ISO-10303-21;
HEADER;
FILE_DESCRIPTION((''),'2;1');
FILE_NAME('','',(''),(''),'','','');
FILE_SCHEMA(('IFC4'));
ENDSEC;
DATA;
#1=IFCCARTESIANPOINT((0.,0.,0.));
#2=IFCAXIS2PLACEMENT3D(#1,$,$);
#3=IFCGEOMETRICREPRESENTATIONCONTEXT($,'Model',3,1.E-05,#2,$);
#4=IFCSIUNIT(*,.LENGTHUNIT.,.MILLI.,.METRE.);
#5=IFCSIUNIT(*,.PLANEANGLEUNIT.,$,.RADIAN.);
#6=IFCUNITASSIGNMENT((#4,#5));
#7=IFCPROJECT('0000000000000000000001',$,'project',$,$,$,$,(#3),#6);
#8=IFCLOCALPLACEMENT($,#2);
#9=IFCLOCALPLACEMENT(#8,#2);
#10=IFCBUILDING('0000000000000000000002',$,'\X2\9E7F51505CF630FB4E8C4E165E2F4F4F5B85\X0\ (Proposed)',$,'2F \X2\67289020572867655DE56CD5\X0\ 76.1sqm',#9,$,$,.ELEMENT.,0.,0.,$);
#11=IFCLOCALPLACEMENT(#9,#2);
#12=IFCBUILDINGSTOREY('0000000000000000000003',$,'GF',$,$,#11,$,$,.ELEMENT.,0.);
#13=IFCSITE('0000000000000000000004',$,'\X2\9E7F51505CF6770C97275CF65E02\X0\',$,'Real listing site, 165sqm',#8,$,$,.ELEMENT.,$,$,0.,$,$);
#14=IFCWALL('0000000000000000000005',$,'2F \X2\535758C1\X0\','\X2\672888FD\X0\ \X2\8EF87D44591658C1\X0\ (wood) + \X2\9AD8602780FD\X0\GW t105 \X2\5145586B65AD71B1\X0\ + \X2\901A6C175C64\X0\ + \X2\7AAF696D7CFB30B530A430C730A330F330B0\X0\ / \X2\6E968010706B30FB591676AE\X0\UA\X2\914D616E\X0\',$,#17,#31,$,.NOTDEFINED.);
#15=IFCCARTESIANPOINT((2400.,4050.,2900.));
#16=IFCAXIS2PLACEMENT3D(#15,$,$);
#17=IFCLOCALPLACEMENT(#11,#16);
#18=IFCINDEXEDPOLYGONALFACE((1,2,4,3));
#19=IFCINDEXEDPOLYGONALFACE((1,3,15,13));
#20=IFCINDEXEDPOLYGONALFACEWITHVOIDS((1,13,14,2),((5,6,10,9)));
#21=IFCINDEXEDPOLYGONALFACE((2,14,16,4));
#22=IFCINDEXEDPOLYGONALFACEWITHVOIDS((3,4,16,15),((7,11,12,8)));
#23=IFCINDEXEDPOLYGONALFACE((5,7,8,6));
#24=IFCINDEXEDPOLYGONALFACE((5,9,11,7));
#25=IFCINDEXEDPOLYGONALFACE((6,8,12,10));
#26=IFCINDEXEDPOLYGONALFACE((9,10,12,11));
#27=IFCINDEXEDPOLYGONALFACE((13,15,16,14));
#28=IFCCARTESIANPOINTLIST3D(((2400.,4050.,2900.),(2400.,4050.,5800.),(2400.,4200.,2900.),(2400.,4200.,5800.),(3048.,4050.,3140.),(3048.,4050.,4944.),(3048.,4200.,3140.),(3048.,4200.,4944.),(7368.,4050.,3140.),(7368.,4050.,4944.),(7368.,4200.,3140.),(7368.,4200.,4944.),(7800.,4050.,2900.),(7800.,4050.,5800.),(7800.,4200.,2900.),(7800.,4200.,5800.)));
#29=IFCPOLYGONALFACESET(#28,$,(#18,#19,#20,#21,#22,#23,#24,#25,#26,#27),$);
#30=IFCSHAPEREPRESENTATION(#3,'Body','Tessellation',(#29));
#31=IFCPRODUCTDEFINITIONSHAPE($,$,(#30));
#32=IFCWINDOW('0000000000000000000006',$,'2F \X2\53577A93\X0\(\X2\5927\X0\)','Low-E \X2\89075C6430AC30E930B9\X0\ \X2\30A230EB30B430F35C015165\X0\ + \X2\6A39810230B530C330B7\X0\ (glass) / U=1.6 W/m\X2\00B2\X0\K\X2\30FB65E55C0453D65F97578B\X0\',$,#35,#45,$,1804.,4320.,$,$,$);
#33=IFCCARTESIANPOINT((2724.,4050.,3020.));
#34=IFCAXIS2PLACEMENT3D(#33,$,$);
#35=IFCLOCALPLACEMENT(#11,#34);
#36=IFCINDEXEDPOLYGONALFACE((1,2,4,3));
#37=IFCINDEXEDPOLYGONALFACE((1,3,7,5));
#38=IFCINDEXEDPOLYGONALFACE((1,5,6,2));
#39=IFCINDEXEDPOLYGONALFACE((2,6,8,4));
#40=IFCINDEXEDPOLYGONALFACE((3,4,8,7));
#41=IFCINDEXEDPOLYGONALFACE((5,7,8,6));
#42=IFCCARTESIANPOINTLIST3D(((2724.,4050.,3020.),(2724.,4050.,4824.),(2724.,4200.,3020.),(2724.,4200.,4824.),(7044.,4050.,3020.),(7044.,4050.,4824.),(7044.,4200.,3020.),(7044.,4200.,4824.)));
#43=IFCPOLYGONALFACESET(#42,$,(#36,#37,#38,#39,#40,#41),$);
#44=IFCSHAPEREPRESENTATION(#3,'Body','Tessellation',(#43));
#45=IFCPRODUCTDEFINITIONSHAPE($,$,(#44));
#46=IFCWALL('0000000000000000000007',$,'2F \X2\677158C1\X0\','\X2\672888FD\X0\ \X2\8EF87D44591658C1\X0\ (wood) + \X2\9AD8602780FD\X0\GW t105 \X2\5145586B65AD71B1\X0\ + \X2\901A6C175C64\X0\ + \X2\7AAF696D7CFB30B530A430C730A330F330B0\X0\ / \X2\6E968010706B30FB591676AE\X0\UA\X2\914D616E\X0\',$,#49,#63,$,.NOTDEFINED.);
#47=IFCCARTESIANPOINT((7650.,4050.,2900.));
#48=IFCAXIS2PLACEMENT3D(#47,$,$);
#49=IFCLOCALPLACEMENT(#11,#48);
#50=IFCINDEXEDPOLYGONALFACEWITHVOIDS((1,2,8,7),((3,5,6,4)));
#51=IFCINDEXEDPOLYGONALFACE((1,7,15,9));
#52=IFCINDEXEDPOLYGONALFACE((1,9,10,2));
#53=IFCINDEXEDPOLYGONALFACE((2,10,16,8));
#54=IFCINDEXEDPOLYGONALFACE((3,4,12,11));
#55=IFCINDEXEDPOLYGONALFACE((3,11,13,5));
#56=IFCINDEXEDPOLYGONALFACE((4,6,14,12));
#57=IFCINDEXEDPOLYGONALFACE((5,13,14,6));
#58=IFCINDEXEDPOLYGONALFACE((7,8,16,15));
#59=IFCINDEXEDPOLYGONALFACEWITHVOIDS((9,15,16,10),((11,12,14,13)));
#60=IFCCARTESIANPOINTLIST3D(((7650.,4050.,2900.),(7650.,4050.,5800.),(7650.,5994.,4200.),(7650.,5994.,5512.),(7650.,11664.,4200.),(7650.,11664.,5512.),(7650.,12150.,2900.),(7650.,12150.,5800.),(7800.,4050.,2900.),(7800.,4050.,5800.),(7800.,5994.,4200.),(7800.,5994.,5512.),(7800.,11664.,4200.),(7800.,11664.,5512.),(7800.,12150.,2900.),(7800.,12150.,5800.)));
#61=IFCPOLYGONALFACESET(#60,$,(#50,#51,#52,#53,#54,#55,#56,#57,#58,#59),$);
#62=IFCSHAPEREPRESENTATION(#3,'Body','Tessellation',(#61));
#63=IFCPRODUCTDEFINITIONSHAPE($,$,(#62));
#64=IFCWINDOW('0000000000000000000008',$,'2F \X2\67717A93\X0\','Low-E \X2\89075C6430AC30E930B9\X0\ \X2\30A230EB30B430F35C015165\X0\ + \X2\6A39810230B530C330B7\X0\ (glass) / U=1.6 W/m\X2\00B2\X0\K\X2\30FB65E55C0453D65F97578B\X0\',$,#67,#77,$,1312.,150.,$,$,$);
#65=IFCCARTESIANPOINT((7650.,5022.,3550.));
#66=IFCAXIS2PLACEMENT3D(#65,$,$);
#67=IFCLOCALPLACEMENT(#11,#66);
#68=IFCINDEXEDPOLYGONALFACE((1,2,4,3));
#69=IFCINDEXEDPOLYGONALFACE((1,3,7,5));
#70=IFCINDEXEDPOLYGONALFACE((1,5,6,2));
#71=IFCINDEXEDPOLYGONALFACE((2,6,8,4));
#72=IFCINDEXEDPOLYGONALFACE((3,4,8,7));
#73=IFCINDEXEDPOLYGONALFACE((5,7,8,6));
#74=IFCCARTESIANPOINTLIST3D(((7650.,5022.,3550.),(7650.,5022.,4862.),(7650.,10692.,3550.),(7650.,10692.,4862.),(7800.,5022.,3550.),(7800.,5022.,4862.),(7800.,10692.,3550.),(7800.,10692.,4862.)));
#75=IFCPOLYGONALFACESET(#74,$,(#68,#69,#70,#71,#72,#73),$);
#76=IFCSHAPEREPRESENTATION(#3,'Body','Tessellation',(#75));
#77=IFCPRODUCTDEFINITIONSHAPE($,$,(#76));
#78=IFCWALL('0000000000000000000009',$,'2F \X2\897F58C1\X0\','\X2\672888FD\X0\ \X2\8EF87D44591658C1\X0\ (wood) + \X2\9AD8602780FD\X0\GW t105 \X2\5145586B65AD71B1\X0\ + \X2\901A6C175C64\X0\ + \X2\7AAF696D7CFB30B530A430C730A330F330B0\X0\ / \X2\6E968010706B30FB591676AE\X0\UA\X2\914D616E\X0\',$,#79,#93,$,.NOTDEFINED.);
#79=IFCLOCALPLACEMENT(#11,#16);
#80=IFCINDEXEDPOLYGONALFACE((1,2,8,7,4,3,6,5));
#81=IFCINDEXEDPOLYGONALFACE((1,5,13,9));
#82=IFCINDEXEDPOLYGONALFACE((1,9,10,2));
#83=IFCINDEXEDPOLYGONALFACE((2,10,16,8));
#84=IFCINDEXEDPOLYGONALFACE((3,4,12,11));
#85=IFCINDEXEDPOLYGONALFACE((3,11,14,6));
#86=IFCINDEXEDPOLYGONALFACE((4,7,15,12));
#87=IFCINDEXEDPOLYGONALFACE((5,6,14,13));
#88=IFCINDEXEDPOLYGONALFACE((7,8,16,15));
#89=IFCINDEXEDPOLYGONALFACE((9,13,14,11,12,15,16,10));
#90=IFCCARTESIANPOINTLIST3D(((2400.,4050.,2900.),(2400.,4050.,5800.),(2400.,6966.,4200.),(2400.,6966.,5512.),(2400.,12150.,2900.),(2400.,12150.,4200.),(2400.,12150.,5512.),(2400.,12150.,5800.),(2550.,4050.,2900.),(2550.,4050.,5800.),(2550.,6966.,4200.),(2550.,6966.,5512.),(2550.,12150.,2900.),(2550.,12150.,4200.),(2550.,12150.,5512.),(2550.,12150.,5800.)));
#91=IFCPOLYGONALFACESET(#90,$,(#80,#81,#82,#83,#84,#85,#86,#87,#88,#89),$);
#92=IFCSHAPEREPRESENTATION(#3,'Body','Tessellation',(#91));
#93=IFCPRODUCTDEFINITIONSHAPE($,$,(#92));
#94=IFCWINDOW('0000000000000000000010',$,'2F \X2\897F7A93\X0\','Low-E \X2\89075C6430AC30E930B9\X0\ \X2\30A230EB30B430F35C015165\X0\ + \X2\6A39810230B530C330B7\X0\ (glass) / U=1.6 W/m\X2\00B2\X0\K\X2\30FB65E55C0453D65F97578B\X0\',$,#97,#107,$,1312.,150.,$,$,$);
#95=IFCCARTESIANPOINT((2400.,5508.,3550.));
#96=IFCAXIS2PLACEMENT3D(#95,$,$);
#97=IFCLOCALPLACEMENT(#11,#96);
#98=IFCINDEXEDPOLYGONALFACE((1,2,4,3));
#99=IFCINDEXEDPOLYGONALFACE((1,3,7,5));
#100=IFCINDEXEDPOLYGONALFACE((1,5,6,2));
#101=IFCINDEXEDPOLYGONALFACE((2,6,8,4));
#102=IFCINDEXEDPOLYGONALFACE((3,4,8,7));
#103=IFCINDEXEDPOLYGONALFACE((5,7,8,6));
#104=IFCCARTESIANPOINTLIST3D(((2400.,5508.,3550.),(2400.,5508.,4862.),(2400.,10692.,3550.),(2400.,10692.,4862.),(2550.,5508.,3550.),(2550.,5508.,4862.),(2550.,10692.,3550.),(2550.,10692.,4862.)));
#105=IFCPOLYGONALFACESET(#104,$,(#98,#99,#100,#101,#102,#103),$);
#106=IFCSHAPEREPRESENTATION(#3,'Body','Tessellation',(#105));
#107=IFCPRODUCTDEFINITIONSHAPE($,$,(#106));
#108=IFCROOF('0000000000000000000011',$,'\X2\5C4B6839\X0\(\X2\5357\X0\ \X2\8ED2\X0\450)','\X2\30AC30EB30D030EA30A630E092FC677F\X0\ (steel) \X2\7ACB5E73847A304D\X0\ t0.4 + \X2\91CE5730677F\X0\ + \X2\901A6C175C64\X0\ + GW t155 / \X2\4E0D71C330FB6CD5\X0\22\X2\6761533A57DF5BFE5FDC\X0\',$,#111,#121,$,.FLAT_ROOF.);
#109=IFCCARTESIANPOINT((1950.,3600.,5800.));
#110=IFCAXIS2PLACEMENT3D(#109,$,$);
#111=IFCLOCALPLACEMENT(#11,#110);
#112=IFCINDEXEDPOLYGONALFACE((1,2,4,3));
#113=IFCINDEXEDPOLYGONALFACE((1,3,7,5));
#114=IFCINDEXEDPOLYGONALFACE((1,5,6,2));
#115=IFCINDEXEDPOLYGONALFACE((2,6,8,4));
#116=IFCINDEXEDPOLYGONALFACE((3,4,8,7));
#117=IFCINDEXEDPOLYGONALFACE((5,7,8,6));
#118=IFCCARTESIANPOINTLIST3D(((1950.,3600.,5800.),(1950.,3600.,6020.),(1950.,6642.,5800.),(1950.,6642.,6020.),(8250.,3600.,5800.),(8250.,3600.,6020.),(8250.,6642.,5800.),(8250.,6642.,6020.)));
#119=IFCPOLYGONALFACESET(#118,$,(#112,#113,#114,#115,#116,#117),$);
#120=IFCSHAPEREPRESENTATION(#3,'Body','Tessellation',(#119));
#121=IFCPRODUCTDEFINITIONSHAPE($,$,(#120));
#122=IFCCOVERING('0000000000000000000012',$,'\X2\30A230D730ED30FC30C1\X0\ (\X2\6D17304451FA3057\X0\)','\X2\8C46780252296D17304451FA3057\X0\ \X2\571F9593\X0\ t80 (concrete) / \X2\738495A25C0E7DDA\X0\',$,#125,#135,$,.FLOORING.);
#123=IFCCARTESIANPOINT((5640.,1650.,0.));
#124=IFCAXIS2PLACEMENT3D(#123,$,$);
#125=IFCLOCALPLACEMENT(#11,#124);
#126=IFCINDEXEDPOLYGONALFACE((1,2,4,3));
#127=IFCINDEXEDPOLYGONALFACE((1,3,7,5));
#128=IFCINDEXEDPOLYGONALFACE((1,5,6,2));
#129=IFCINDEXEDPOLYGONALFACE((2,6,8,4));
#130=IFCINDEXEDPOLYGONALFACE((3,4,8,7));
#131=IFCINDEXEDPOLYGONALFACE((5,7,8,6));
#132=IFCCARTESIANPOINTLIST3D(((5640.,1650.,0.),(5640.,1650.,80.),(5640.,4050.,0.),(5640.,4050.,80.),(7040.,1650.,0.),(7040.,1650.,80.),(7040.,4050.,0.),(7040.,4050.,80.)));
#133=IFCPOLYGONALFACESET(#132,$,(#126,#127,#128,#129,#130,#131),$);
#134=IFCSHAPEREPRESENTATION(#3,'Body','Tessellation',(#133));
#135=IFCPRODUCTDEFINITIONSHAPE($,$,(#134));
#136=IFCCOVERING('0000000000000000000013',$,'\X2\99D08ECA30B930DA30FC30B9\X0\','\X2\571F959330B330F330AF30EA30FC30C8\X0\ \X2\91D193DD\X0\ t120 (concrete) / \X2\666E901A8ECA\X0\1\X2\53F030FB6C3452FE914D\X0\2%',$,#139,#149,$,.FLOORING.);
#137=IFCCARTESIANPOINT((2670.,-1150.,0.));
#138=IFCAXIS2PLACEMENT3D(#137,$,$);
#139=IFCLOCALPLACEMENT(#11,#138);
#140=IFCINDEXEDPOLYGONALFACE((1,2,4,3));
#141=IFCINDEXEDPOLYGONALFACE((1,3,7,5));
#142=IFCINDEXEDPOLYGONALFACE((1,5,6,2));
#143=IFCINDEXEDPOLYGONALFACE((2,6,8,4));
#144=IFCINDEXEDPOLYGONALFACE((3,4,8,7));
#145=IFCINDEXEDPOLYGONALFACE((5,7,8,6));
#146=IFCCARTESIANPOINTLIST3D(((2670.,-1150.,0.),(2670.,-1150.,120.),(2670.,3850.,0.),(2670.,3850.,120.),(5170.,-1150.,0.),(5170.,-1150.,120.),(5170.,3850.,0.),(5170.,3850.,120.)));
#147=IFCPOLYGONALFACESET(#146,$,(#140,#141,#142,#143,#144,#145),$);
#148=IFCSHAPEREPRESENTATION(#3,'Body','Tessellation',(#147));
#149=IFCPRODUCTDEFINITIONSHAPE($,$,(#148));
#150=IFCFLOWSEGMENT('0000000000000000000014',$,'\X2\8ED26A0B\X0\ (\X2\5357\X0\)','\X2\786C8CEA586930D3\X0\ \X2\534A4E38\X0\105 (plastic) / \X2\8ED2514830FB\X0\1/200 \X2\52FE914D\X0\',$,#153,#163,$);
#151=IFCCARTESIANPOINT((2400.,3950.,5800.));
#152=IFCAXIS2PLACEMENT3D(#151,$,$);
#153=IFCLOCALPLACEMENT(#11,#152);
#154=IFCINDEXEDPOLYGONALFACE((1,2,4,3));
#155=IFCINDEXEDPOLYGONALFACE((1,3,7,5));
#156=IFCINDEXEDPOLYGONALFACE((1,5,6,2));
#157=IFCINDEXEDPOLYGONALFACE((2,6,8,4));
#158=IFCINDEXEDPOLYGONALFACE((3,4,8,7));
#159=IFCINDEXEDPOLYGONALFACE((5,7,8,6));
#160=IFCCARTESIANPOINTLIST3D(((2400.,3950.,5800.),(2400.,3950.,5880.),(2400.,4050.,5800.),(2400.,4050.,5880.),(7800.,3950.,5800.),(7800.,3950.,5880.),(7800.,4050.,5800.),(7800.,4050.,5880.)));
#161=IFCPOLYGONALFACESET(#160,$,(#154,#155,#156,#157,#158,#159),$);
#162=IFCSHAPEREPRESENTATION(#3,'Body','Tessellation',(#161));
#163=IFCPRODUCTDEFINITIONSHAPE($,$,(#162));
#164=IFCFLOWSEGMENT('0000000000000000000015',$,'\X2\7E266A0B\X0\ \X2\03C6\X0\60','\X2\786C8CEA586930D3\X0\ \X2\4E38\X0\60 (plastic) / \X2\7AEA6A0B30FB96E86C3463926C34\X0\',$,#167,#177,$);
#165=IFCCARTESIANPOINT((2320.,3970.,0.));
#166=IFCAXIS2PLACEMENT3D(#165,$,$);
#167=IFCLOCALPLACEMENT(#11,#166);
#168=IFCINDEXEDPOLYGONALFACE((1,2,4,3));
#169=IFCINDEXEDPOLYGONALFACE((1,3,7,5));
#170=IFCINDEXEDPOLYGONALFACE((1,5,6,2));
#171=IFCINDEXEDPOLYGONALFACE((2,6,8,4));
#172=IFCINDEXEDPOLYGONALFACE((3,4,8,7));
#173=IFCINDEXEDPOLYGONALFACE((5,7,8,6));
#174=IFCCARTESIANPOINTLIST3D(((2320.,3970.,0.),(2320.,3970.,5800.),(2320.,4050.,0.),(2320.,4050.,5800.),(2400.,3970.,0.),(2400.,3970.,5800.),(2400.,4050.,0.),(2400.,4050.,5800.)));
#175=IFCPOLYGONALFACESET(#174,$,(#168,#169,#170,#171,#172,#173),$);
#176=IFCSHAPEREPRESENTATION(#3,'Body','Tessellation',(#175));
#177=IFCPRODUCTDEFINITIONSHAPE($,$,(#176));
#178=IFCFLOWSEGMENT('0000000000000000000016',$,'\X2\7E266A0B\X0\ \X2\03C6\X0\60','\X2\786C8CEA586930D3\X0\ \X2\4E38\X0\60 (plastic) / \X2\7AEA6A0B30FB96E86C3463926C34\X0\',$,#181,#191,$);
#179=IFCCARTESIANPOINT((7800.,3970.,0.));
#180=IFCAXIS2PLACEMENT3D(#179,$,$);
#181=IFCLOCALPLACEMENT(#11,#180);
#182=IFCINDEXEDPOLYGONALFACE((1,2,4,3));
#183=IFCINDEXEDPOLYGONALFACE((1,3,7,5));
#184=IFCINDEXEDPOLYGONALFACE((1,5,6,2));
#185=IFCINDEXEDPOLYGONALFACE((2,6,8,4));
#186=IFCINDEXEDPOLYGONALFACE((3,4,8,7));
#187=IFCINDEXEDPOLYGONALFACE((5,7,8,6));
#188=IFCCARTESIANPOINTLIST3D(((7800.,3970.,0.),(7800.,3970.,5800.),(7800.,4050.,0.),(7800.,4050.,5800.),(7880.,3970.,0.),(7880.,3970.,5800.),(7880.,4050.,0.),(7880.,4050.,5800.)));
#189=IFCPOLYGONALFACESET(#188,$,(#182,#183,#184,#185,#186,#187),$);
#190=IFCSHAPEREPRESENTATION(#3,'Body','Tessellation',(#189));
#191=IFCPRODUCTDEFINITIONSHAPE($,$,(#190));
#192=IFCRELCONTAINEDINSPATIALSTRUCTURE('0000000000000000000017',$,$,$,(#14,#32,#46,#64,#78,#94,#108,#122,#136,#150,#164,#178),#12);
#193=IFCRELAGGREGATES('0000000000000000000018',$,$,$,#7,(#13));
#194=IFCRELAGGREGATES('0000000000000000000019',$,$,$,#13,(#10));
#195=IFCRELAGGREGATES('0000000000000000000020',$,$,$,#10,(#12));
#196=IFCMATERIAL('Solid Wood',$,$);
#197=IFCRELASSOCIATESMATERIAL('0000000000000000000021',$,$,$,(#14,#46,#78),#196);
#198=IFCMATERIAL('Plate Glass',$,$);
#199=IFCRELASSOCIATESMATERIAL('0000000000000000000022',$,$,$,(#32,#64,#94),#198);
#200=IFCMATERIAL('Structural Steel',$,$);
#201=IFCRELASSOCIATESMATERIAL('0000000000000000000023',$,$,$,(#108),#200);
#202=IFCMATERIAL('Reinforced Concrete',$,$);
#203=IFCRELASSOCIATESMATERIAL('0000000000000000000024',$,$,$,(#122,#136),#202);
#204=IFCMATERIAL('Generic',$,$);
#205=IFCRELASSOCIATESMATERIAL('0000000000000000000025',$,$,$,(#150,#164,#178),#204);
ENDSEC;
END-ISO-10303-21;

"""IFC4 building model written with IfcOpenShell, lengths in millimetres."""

from ifc_helpers import new_model, si_unit, frame, frame_2d, origin, place, context, project, spatial, rectangle, extrude, material, element, fill, save


model = new_model("IFC4")

# Units and contexts
model_context = context("Model", 3, precision=1e-05, world=origin())
ifc_project = project(units=[si_unit("LENGTHUNIT", "METRE", prefix="MILLI"), si_unit("PLANEANGLEUNIT", "RADIAN")], contexts=[model_context])

# Site, building, storey
site_placement = place(None, origin())
site = spatial("IfcSite", under=ifc_project, at=site_placement, Name="鹿児島県霧島市", ObjectType="Real listing site, 165sqm", CompositionType="ELEMENT", RefElevation=0.0)
building_placement = place(site_placement, origin())
building = spatial("IfcBuilding", under=site, at=building_placement, Name="鹿児島・二世帯住宅 (Proposed)", ObjectType="2F 木造在来工法 76.1sqm", CompositionType="ELEMENT", ElevationOfRefHeight=0.0, ElevationOfTerrain=0.0)
storey_placement = place(building_placement, origin())
storey = spatial("IfcBuildingStorey", under=building, at=storey_placement, Name="GF", CompositionType="ELEMENT", Elevation=0.0)

# Shared definitions
ifc_material_1 = material(Name="Solid Wood")

# Shared definitions
ifc_material_2 = material(Name="Reinforced Concrete")

# Shared definitions
ifc_material_3 = material(Name="Plate Glass")

# Walls, openings, windows
wall_1_placement = place(storey_placement, frame((2400.0, 4050.0, 2900.0)))
wall_1 = element("IfcWall", 1, at=wall_1_placement, inside=storey, material=ifc_material_1, Name="2F 南壁", Description="木製 軸組外壁 (wood) + 高性能GW t105 充填断熱 + 通気層 + 窯業系サイディング / 準耐火・外皮UA配慮", PredefinedType="NOTDEFINED", context=model_context, shape_type="SweptSolid", body=[
    extrude(rectangle(XDim=5400.0, YDim=150.0, at=frame_2d((2700.0, 75.0))), frame((2400.0, 4050.0, 2900.0)), (0.0, 0.0, 1.0), 2900.0),
])
opening_1_placement = place(storey_placement, frame((2724.0, 4050.0, 3020.0)))
opening_1 = element("IfcOpeningElement", 2, at=opening_1_placement, cuts=wall_1, PredefinedType="NOTDEFINED", context=model_context, shape_type="SweptSolid", body=[
    extrude(rectangle(XDim=4320.0, YDim=150.0, at=frame_2d((2160.0, 75.0))), frame((2724.0, 4050.0, 3020.0)), (0.0, 0.0, 1.0), 1804.0),
])
window_1_placement = place(storey_placement, frame((2724.0, 4050.0, 3020.0)))
window_1 = element("IfcWindow", 3, at=window_1_placement, inside=storey, material=ifc_material_3, Name="2F 南窓(大)", Description="Low-E 複層ガラス アルゴン封入 + 樹脂サッシ (glass) / U=1.6 W/m²K・日射取得型", OverallHeight=1804.0, OverallWidth=4320.0, context=model_context, shape_type="SweptSolid", body=[
    extrude(rectangle(XDim=4320.0, YDim=150.0, at=frame_2d((2160.0, 75.0))), frame((2724.0, 4050.0, 3020.0)), (0.0, 0.0, 1.0), 1804.0),
])
fill(opening_1, window_1)
wall_2_placement = place(storey_placement, frame((7650.0, 4050.0, 2900.0)))
wall_2 = element("IfcWall", 4, at=wall_2_placement, inside=storey, material=ifc_material_1, Name="2F 東壁", Description="木製 軸組外壁 (wood) + 高性能GW t105 充填断熱 + 通気層 + 窯業系サイディング / 準耐火・外皮UA配慮", PredefinedType="NOTDEFINED", context=model_context, shape_type="SweptSolid", body=[
    extrude(rectangle(XDim=150.0, YDim=8100.0, at=frame_2d((75.0, 4050.0))), frame((7650.0, 4050.0, 2900.0)), (0.0, 0.0, 1.0), 2900.0),
])
opening_2_placement = place(storey_placement, frame((7650.0, 5022.0, 3550.0)))
opening_2 = element("IfcOpeningElement", 5, at=opening_2_placement, cuts=wall_2, PredefinedType="NOTDEFINED", context=model_context, shape_type="SweptSolid", body=[
    extrude(rectangle(XDim=150.0, YDim=5670.0, at=frame_2d((75.0, 2835.0))), frame((7650.0, 5022.0, 3550.0)), (0.0, 0.0, 1.0), 1312.0),
])
window_2_placement = place(storey_placement, frame((7650.0, 5022.0, 3550.0)))
window_2 = element("IfcWindow", 6, at=window_2_placement, inside=storey, material=ifc_material_3, Name="2F 東窓", Description="Low-E 複層ガラス アルゴン封入 + 樹脂サッシ (glass) / U=1.6 W/m²K・日射取得型", OverallHeight=1312.0, OverallWidth=150.0, context=model_context, shape_type="SweptSolid", body=[
    extrude(rectangle(XDim=150.0, YDim=5670.0, at=frame_2d((75.0, 2835.0))), frame((7650.0, 5022.0, 3550.0)), (0.0, 0.0, 1.0), 1312.0),
])
fill(opening_2, window_2)
wall_3_placement = place(storey_placement, frame((2400.0, 4050.0, 2900.0)))
wall_3 = element("IfcWall", 7, at=wall_3_placement, inside=storey, material=ifc_material_1, Name="2F 西壁", Description="木製 軸組外壁 (wood) + 高性能GW t105 充填断熱 + 通気層 + 窯業系サイディング / 準耐火・外皮UA配慮", PredefinedType="NOTDEFINED", context=model_context, shape_type="SweptSolid", body=[
    extrude(rectangle(XDim=150.0, YDim=8100.0, at=frame_2d((75.0, 4050.0))), frame((2400.0, 4050.0, 2900.0)), (0.0, 0.0, 1.0), 2900.0),
])
opening_3_placement = place(storey_placement, frame((2400.0, 5508.0, 3550.0)))
opening_3 = element("IfcOpeningElement", 8, at=opening_3_placement, cuts=wall_3, PredefinedType="NOTDEFINED", context=model_context, shape_type="SweptSolid", body=[
    extrude(rectangle(XDim=150.0, YDim=5184.0, at=frame_2d((75.0, 2592.0))), frame((2400.0, 5508.0, 3550.0)), (0.0, 0.0, 1.0), 1312.0),
])
window_3_placement = place(storey_placement, frame((2400.0, 5508.0, 3550.0)))
window_3 = element("IfcWindow", 9, at=window_3_placement, inside=storey, material=ifc_material_3, Name="2F 西窓", Description="Low-E 複層ガラス アルゴン封入 + 樹脂サッシ (glass) / U=1.6 W/m²K・日射取得型", OverallHeight=1312.0, OverallWidth=150.0, context=model_context, shape_type="SweptSolid", body=[
    extrude(rectangle(XDim=150.0, YDim=5184.0, at=frame_2d((75.0, 2592.0))), frame((2400.0, 5508.0, 3550.0)), (0.0, 0.0, 1.0), 1312.0),
])
fill(opening_3, window_3)

# Roof
ifc_material_4 = material(Name="Structural Steel")
for number, where, name in (
    (10, (1950.0, 3600.0, 5800.0), "屋根(南 軒450)"),
):
    element("IfcRoof", number, at=place(storey_placement, frame(where)), inside=storey, material=ifc_material_4, Name=name, Description="ガルバリウム鋼板 (steel) 立平葺き t0.4 + 野地板 + 通気層 + GW t155 / 不燃・法22条区域対応", PredefinedType="FLAT_ROOF", context=model_context, shape_type="SweptSolid", body=[
        extrude(rectangle(XDim=6300.0, YDim=3042.0, at=frame_2d((3150.0, 1521.0))), frame((1950.0, 3600.0, 5800.0)), (0.0, 0.0, 1.0), 220.0),
    ])

# Coverings
covering_1_placement = place(storey_placement, frame((5640.0, 1650.0, 0.0)))
element("IfcCovering", 11, at=covering_1_placement, inside=storey, material=ifc_material_2, Name="アプローチ (洗い出し)", Description="豆砂利洗い出し 土間 t80 (concrete) / 玄関導線", PredefinedType="FLOORING", context=model_context, shape_type="SweptSolid", body=[
    extrude(rectangle(XDim=1400.0, YDim=2400.0, at=frame_2d((700.0, 1200.0))), frame((5640.0, 1650.0, 0.0)), (0.0, 0.0, 1.0), 80.0),
])
covering_2_placement = place(storey_placement, frame((2670.0, -1150.0, 0.0)))
element("IfcCovering", 12, at=covering_2_placement, inside=storey, material=ifc_material_2, Name="駐車スペース", Description="土間コンクリート 金鏝 t120 (concrete) / 普通車1台・水勾配2%", PredefinedType="FLOORING", context=model_context, shape_type="SweptSolid", body=[
    extrude(rectangle(XDim=2500.0, YDim=5000.0, at=frame_2d((1250.0, 2500.0))), frame((2670.0, -1150.0, 0.0)), (0.0, 0.0, 1.0), 120.0),
])

# Flow segments
ifc_material_5 = material(Name="Generic")
flow_segment_1_placement = place(storey_placement, frame((2400.0, 3950.0, 5800.0)))
element("IfcFlowSegment", 13, at=flow_segment_1_placement, inside=storey, material=ifc_material_5, Name="軒樋 (南)", Description="硬質塩ビ 半丸105 (plastic) / 軒先・1/200 勾配", context=model_context, shape_type="SweptSolid", body=[
    extrude(rectangle(XDim=5400.0, YDim=100.0, at=frame_2d((2700.0, 50.0))), frame((2400.0, 3950.0, 5800.0)), (0.0, 0.0, 1.0), 80.0),
])
flow_segment_2_placement = place(storey_placement, frame((2320.0, 3970.0, 0.0)))
element("IfcFlowSegment", 14, at=flow_segment_2_placement, inside=storey, material=ifc_material_5, Name="縦樋 φ60", Description="硬質塩ビ 丸60 (plastic) / 竪樋・雨水排水", context=model_context, shape_type="SweptSolid", body=[
    extrude(rectangle(XDim=80.0, YDim=80.0, at=frame_2d((40.0, 40.0))), frame((2320.0, 3970.0, 0.0)), (0.0, 0.0, 1.0), 5800.0),
])
flow_segment_3_placement = place(storey_placement, frame((7800.0, 3970.0, 0.0)))
element("IfcFlowSegment", 15, at=flow_segment_3_placement, inside=storey, material=ifc_material_5, Name="縦樋 φ60", Description="硬質塩ビ 丸60 (plastic) / 竪樋・雨水排水", context=model_context, shape_type="SweptSolid", body=[
    extrude(rectangle(XDim=80.0, YDim=80.0, at=frame_2d((40.0, 40.0))), frame((7800.0, 3970.0, 0.0)), (0.0, 0.0, 1.0), 5800.0),
])

save(model, "model.ifc")
